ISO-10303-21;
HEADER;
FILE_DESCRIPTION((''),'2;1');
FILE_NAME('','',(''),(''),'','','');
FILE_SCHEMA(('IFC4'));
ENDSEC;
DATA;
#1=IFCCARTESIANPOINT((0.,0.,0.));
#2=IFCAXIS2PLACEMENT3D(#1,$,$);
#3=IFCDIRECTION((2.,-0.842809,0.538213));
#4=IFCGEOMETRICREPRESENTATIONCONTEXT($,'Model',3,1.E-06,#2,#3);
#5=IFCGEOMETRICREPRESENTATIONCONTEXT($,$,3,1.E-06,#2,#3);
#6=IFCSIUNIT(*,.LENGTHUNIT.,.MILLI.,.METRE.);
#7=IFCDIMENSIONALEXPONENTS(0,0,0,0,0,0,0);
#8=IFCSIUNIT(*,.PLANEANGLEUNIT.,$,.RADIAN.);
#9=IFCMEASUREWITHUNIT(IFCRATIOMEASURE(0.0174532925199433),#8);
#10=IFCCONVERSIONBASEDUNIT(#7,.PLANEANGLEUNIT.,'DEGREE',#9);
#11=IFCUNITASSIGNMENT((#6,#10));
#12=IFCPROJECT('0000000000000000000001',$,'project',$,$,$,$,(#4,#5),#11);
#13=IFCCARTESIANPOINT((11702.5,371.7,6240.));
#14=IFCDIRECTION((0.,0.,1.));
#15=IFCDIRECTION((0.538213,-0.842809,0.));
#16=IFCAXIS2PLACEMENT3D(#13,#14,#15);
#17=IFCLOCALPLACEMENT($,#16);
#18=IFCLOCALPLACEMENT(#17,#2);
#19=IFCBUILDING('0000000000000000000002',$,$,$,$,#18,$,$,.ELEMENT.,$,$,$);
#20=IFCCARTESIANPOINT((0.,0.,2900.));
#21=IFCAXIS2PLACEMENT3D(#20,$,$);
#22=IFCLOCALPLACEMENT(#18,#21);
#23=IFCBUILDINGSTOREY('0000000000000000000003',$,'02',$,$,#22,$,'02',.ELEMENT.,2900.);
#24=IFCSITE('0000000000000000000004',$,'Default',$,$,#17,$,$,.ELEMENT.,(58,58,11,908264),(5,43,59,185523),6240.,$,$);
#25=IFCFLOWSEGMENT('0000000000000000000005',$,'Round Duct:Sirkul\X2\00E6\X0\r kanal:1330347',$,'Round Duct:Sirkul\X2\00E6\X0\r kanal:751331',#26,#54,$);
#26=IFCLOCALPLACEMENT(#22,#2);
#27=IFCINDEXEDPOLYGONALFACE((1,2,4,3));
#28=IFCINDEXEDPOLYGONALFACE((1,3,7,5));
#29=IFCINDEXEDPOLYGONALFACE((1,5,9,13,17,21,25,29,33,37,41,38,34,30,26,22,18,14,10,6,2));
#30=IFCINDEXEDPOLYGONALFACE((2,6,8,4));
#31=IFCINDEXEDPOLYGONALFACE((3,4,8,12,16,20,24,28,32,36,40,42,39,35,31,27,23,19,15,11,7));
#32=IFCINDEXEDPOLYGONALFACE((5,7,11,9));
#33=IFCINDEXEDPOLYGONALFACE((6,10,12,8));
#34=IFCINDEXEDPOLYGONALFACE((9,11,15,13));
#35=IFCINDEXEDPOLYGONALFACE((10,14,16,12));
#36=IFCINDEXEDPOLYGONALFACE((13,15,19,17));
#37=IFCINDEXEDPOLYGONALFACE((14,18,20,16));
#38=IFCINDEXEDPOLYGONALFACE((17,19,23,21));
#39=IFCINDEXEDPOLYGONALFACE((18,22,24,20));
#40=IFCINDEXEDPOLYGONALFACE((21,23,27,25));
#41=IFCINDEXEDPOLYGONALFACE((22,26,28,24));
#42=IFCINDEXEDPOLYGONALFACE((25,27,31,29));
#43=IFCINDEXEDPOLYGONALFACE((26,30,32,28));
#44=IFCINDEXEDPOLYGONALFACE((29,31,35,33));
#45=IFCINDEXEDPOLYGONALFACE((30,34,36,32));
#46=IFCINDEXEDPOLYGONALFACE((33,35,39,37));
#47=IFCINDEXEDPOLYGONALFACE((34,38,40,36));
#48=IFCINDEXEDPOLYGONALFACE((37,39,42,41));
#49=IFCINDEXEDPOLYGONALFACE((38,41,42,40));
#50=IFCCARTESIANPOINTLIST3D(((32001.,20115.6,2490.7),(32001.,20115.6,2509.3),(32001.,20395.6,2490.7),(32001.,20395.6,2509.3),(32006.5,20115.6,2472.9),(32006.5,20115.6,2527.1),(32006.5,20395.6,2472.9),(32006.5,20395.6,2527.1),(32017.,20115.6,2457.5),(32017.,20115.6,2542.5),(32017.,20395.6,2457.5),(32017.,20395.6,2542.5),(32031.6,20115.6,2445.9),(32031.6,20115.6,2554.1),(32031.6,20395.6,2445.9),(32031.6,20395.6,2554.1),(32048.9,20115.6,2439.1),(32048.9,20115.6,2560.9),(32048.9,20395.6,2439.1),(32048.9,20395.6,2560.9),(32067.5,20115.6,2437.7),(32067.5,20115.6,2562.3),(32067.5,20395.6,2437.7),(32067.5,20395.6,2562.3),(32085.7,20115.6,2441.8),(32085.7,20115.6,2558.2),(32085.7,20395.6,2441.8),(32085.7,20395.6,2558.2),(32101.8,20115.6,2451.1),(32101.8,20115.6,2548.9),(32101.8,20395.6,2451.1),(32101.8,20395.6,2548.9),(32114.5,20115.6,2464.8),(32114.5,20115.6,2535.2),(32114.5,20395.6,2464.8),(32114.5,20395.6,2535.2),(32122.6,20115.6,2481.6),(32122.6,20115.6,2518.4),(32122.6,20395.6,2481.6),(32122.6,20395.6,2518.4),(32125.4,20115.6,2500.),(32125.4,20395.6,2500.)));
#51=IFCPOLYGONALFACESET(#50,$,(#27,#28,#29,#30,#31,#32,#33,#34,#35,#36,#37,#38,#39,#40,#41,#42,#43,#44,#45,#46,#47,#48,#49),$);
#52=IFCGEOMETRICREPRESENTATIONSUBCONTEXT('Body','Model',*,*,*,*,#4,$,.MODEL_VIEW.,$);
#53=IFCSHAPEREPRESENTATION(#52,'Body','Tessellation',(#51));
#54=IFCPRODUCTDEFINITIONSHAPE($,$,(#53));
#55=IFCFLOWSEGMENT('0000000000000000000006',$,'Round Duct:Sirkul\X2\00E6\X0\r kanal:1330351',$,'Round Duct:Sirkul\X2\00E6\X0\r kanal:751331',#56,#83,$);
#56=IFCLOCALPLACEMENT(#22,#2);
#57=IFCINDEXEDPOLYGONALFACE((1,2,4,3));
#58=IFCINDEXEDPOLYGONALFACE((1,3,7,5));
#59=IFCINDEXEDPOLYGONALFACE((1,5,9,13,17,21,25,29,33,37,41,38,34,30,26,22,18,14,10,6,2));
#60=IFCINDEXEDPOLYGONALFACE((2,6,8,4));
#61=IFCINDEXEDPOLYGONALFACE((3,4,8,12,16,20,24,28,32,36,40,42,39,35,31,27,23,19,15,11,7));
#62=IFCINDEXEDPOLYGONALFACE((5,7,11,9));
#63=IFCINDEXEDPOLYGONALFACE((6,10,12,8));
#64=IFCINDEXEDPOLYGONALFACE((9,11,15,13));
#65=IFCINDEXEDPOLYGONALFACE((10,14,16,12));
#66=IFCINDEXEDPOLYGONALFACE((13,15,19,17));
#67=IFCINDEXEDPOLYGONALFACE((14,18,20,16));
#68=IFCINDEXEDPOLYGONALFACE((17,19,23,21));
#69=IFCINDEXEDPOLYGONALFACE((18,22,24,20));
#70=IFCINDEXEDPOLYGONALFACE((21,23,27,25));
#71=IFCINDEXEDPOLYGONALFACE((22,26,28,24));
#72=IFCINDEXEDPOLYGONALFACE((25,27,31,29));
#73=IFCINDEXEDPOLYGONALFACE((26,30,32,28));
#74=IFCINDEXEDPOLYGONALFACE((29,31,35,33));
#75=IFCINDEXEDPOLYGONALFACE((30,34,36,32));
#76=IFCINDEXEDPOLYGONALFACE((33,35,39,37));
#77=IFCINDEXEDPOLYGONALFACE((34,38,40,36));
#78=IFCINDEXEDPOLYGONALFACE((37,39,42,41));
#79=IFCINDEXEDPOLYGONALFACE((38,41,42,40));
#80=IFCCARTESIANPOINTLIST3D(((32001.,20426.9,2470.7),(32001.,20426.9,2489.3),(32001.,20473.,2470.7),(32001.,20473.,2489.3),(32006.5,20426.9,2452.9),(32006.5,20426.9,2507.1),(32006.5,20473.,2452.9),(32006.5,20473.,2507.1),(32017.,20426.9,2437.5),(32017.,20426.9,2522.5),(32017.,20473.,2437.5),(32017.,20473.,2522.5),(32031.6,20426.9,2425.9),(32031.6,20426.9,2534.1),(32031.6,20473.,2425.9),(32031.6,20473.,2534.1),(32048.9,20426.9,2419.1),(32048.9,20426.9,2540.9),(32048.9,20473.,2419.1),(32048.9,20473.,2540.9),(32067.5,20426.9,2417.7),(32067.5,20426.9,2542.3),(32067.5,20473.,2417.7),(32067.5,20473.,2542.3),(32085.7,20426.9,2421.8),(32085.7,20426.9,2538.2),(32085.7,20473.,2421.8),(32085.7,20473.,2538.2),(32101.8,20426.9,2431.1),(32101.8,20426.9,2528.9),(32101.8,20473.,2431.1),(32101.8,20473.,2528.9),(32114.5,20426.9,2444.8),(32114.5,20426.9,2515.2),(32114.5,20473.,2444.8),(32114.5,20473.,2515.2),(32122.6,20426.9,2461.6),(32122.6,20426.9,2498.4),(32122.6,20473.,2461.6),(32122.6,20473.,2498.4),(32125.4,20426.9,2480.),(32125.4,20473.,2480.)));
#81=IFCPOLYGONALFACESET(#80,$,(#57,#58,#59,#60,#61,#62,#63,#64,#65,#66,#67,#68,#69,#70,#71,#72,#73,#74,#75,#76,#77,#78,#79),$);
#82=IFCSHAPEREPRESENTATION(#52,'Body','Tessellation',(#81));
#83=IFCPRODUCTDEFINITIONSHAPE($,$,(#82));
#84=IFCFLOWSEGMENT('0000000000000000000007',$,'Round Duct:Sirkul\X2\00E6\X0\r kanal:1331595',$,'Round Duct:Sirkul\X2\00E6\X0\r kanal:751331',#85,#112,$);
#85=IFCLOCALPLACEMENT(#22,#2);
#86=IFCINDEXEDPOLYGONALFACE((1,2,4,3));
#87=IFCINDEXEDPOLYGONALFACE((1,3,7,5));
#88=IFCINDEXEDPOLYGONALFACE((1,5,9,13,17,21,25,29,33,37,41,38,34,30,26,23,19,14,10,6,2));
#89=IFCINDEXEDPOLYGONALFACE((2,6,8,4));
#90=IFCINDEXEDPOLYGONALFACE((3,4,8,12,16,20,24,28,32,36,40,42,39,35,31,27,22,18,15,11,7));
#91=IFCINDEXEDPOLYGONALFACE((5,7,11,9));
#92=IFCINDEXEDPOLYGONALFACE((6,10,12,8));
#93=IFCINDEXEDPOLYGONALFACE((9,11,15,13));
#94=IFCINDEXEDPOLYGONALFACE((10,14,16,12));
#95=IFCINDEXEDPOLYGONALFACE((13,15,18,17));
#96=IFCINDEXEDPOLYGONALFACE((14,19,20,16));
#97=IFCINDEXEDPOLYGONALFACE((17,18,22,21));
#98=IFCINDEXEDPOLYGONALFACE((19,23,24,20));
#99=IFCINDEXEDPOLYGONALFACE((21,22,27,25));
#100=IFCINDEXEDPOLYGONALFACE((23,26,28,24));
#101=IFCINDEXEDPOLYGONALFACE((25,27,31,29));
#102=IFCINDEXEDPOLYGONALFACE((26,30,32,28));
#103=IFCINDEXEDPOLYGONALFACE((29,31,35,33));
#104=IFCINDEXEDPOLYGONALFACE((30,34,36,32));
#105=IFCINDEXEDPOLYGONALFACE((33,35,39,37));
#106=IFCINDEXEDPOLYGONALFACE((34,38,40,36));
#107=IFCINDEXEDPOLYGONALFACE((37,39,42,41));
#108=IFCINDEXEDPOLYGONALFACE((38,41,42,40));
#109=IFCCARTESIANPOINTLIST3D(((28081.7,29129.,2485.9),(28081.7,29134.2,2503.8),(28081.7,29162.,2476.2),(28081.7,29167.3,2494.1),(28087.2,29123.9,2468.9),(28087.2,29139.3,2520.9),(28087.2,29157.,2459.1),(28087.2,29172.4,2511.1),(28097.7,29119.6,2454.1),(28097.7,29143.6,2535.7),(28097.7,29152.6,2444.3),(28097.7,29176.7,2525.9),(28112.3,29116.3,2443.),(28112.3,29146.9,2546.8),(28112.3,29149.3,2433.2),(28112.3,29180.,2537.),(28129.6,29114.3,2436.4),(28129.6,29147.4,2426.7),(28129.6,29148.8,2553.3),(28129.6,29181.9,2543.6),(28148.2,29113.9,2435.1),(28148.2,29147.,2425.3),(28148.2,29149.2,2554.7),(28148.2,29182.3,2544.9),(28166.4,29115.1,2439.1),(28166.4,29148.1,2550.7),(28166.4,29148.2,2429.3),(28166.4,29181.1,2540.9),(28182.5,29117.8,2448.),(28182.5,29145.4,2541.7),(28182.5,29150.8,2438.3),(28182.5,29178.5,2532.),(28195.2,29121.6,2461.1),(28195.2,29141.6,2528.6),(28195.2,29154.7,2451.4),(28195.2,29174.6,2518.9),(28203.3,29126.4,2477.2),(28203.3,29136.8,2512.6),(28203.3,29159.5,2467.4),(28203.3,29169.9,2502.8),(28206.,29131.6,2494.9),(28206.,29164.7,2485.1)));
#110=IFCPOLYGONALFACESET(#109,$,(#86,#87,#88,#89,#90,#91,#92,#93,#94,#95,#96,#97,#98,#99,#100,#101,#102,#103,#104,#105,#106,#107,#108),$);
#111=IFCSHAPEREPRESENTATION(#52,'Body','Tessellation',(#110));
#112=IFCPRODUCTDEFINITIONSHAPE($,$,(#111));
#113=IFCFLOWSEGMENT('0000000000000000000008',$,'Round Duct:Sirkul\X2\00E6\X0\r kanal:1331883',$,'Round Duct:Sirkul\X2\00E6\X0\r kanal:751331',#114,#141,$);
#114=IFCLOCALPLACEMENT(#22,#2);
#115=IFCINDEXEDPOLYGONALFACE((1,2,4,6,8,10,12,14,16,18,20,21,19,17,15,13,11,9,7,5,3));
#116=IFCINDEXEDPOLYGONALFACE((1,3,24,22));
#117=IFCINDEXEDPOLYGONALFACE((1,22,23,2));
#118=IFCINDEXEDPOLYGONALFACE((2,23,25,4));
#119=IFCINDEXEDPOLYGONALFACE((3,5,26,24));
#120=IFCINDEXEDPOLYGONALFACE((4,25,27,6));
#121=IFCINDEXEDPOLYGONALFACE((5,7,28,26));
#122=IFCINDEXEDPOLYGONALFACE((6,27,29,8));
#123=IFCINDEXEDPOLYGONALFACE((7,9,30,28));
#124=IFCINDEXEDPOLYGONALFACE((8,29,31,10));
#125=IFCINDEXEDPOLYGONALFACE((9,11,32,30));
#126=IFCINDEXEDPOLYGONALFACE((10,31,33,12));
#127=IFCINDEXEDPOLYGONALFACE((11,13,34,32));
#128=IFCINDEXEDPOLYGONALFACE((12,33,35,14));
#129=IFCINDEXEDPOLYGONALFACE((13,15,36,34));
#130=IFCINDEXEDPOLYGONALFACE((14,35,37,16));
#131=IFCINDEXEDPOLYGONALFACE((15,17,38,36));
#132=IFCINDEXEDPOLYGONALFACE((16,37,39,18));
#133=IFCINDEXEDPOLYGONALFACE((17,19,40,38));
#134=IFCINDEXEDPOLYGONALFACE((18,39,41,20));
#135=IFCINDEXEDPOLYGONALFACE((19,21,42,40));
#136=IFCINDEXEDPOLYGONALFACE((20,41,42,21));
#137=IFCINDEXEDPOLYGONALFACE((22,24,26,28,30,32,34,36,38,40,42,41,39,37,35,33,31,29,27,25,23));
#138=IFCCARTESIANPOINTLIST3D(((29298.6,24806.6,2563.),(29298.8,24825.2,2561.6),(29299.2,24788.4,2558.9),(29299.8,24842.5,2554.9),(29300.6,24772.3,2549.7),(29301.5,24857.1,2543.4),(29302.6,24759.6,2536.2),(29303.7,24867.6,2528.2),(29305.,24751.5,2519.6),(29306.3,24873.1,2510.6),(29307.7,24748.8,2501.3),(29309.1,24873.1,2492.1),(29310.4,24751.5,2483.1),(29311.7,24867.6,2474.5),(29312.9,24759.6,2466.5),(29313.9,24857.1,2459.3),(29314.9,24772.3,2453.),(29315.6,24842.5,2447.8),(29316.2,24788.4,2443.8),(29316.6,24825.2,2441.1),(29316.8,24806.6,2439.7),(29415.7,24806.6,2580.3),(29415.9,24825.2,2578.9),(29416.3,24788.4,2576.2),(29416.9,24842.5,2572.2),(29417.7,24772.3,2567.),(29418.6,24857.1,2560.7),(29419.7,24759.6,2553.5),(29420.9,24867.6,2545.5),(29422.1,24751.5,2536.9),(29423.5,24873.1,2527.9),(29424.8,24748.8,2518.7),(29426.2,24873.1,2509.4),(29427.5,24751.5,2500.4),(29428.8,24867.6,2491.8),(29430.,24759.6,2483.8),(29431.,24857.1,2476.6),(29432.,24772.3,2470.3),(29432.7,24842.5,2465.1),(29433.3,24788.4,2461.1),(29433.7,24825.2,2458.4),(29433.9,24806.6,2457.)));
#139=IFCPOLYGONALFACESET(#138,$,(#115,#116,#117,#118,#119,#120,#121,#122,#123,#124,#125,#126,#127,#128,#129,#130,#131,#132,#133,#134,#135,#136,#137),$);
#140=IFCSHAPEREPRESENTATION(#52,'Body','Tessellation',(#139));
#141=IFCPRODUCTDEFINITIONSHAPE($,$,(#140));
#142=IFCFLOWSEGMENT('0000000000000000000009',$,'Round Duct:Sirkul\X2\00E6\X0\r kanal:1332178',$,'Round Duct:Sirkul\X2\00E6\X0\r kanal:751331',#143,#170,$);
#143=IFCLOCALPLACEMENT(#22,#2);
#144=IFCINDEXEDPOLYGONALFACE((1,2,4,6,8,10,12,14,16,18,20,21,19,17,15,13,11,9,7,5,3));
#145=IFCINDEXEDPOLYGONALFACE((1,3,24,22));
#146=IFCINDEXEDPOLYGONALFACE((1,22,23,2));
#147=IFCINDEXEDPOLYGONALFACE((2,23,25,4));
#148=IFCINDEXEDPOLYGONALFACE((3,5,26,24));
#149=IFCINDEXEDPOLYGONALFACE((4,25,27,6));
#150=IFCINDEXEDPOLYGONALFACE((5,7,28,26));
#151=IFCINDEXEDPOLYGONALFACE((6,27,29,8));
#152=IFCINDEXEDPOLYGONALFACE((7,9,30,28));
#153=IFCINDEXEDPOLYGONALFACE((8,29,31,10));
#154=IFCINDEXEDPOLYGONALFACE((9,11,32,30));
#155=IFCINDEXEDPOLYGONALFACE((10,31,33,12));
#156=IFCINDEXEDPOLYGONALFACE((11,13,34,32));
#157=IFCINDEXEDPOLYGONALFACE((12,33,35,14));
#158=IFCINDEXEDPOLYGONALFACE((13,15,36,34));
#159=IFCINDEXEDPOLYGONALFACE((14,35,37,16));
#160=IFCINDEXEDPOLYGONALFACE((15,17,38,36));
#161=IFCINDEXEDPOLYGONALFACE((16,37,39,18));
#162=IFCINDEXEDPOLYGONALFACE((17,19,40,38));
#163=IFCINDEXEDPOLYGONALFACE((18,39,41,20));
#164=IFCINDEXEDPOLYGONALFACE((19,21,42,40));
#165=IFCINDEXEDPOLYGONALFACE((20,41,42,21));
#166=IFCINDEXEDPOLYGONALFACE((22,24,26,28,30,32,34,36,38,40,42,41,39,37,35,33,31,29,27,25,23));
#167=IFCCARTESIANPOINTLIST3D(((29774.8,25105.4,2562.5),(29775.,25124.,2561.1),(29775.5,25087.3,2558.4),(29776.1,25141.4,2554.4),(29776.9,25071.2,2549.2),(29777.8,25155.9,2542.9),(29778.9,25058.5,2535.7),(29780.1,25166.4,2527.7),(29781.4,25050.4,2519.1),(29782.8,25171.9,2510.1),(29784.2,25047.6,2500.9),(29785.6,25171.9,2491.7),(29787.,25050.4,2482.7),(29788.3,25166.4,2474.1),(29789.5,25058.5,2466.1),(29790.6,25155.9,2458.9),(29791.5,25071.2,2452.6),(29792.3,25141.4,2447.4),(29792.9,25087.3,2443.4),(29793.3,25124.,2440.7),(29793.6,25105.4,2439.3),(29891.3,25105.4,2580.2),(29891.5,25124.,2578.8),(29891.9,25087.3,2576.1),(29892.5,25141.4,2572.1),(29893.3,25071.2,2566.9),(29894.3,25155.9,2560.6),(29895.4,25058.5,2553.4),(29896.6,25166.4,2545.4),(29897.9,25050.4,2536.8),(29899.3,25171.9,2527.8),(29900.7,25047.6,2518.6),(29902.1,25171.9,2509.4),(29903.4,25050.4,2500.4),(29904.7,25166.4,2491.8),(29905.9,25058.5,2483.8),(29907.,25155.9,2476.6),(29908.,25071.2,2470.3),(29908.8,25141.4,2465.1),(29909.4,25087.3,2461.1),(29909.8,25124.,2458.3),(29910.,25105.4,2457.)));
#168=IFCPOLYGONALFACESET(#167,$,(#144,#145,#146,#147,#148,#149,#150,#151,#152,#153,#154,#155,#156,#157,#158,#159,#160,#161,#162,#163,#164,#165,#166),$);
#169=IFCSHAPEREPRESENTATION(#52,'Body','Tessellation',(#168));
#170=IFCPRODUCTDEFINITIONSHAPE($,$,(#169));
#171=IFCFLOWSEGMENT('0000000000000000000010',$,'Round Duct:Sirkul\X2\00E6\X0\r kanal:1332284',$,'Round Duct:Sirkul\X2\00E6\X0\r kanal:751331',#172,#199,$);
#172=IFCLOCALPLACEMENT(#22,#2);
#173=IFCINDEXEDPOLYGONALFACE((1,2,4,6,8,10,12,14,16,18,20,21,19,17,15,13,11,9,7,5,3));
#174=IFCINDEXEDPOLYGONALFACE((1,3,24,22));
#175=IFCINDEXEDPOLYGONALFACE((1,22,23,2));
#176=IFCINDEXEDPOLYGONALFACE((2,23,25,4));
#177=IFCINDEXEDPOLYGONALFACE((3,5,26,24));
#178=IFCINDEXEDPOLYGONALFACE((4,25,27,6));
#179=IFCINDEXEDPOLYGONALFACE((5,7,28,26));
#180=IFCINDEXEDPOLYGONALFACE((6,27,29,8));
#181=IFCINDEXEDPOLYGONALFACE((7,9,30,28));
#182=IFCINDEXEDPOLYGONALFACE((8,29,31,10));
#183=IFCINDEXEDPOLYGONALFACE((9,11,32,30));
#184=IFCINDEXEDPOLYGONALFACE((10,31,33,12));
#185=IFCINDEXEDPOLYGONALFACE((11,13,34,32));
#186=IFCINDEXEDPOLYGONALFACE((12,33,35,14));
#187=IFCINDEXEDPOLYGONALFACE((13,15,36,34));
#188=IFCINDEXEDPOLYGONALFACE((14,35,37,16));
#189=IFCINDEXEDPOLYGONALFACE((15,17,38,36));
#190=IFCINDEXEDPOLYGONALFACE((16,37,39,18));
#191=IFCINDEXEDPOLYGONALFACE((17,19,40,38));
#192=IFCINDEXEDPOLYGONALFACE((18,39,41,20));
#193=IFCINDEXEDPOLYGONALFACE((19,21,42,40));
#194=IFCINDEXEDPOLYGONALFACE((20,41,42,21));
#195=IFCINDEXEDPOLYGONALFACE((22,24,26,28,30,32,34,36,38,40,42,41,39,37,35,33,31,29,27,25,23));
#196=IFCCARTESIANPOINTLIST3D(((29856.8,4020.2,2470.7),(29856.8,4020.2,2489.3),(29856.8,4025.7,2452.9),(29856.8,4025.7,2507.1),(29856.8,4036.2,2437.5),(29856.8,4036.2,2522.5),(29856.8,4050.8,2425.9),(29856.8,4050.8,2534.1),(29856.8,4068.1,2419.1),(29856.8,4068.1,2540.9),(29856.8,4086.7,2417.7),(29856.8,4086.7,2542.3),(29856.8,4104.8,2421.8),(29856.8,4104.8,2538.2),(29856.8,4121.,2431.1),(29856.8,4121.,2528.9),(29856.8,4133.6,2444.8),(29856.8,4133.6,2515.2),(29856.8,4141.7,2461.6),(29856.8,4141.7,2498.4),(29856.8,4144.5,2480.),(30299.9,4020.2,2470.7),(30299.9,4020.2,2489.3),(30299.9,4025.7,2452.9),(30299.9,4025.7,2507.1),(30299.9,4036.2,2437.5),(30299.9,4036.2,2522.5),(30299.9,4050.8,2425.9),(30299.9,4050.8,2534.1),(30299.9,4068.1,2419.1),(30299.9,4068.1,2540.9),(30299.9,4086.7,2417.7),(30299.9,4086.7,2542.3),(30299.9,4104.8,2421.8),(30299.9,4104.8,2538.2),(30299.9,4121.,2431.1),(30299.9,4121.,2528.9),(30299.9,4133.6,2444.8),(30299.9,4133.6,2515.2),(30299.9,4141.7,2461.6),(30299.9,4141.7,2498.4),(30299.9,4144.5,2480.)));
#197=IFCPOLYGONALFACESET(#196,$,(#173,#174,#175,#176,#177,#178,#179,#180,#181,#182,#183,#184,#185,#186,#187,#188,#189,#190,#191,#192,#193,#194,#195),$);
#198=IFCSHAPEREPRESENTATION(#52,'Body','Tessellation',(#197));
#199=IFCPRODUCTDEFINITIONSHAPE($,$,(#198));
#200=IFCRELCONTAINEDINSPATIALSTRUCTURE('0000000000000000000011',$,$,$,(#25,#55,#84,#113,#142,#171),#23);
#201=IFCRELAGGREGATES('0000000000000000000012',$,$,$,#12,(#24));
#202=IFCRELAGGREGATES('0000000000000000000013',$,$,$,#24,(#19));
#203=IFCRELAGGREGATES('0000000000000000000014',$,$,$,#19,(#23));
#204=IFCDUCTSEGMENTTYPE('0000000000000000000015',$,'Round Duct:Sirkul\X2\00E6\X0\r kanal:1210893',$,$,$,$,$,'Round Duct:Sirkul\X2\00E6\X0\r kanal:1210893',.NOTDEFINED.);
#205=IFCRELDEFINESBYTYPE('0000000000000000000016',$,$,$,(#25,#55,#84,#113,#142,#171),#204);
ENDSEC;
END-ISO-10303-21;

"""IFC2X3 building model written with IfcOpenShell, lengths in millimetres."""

from ifc_helpers import new_model, entity, si_unit, converted_unit, direction, frame, frame_2d, origin, origin_2d_with_axis, place, context, subcontext, project, spatial, circle, extrude, type_object, element, save


model = new_model("IFC2X3")

# Units and contexts
model_context = context("Model", 3, precision=1e-06, world=origin(), true_north=direction((2.0, -0.842809, 0.538213)))
context_of_model = context(None, 3, precision=1e-06, world=origin(), true_north=direction((2.0, -0.842809, 0.538213)))
body_context = subcontext(model_context, "Body", "Model", "MODEL_VIEW")
ifc_project = project(units=[si_unit("LENGTHUNIT", "METRE", prefix="MILLI"), converted_unit("PLANEANGLEUNIT", "DEGREE", entity("IfcRatioMeasure", 0.0174532925199433), si_unit("PLANEANGLEUNIT", "RADIAN"), dimensions=[0, 0, 0, 0, 0, 0, 0])], contexts=[model_context, context_of_model])

# Site, building, storey
site_placement = place(None, frame((11702.5, 371.7, 6240.0), z_axis=(0.0, 0.0, 1.0), x_axis=(0.538213, -0.842809, 0.0)))
site = spatial("IfcSite", under=ifc_project, at=site_placement, Name="Default", CompositionType="ELEMENT", RefLatitude=(58, 58, 11, 908264), RefLongitude=(5, 43, 59, 185523), RefElevation=6240.0)
building_placement = place(site_placement, origin())
building = spatial("IfcBuilding", under=site, at=building_placement, CompositionType="ELEMENT")
storey_placement = place(building_placement, frame((0.0, 0.0, 2900.0)))
storey = spatial("IfcBuildingStorey", under=building, at=storey_placement, Name="02", LongName="02", CompositionType="ELEMENT", Elevation=2900.0)

# Flow segments
duct_segment_type_1 = type_object("IfcDuctSegmentType", Name="Round Duct:Sirkulær kanal:1210893", ElementType="Round Duct:Sirkulær kanal:1210893", PredefinedType="NOTDEFINED")
flow_segment_1_placement = place(storey_placement, origin())
element("IfcFlowSegment", 1, at=flow_segment_1_placement, inside=storey, type_object=duct_segment_type_1, Name="Round Duct:Sirkulær kanal:1330347", ObjectType="Round Duct:Sirkulær kanal:751331", context=body_context, shape_type="SweptSolid", body=[
    extrude(circle(Radius=62.5, at=origin_2d_with_axis()), frame((32062.9, 20115.6, 2500.0), z_axis=(0.0, 1.0, 0.0), x_axis=(1.0, 0.0, 0.0)), (0.0, 0.0, 1.0), 280.0),
])
flow_segment_2_placement = place(storey_placement, origin())
element("IfcFlowSegment", 2, at=flow_segment_2_placement, inside=storey, type_object=duct_segment_type_1, Name="Round Duct:Sirkulær kanal:1330351", ObjectType="Round Duct:Sirkulær kanal:751331", context=body_context, shape_type="SweptSolid", body=[
    extrude(circle(Radius=62.5, at=origin_2d_with_axis()), frame((32062.9, 20426.9, 2480.0), z_axis=(0.0, 1.0, 0.0), x_axis=(1.0, 0.0, 0.0)), (0.0, 0.0, 1.0), 46.1),
])
flow_segment_3_placement = place(storey_placement, origin())
element("IfcFlowSegment", 3, at=flow_segment_3_placement, inside=storey, type_object=duct_segment_type_1, Name="Round Duct:Sirkulær kanal:1331595", ObjectType="Round Duct:Sirkulær kanal:751331", context=body_context, shape_type="SweptSolid", body=[
    extrude(circle(Radius=62.5, at=frame_2d((0.0, 0.0), x_axis=(1.0, 0.0))), frame((28143.5, 29131.6, 2494.9), z_axis=(0.0, 0.959068, -0.283175), x_axis=(1.0, 0.0, 0.0)), (0.0, 0.0, 1.0), 34.5),
])
flow_segment_4_placement = place(storey_placement, origin())
element("IfcFlowSegment", 4, at=flow_segment_4_placement, inside=storey, type_object=duct_segment_type_1, Name="Round Duct:Sirkulær kanal:1331883", ObjectType="Round Duct:Sirkulær kanal:751331", context=body_context, shape_type="SweptSolid", body=[
    extrude(circle(Radius=62.5, at=origin_2d_with_axis()), frame((29307.7, 24811.3, 2501.3), z_axis=(0.98925, 0.0, 0.146233), x_axis=(0.0, -1.0, 0.0)), (0.0, 0.0, 1.0), 118.4),
])
flow_segment_5_placement = place(storey_placement, origin())
element("IfcFlowSegment", 5, at=flow_segment_5_placement, inside=storey, type_object=duct_segment_type_1, Name="Round Duct:Sirkulær kanal:1332178", ObjectType="Round Duct:Sirkulær kanal:751331", context=body_context, shape_type="SweptSolid", body=[
    extrude(circle(Radius=62.5, at=origin_2d_with_axis()), frame((29784.2, 25110.1, 2500.9), z_axis=(0.988662, 0.0, 0.150158), x_axis=(0.0, -1.0, 0.0)), (0.0, 0.0, 1.0), 117.8),
])
flow_segment_6_placement = place(storey_placement, origin())
element("IfcFlowSegment", 6, at=flow_segment_6_placement, inside=storey, type_object=duct_segment_type_1, Name="Round Duct:Sirkulær kanal:1332284", ObjectType="Round Duct:Sirkulær kanal:751331", context=body_context, shape_type="SweptSolid", body=[
    extrude(circle(Radius=62.5, at=frame_2d((0.0, 0.0), x_axis=(1.0, 0.0))), frame((29856.8, 4082.0, 2480.0), z_axis=(1.0, 0.0, 0.0), x_axis=(0.0, 1.0, 0.0)), (0.0, 0.0, 1.0), 443.0),
])

save(model, "model.ifc")
